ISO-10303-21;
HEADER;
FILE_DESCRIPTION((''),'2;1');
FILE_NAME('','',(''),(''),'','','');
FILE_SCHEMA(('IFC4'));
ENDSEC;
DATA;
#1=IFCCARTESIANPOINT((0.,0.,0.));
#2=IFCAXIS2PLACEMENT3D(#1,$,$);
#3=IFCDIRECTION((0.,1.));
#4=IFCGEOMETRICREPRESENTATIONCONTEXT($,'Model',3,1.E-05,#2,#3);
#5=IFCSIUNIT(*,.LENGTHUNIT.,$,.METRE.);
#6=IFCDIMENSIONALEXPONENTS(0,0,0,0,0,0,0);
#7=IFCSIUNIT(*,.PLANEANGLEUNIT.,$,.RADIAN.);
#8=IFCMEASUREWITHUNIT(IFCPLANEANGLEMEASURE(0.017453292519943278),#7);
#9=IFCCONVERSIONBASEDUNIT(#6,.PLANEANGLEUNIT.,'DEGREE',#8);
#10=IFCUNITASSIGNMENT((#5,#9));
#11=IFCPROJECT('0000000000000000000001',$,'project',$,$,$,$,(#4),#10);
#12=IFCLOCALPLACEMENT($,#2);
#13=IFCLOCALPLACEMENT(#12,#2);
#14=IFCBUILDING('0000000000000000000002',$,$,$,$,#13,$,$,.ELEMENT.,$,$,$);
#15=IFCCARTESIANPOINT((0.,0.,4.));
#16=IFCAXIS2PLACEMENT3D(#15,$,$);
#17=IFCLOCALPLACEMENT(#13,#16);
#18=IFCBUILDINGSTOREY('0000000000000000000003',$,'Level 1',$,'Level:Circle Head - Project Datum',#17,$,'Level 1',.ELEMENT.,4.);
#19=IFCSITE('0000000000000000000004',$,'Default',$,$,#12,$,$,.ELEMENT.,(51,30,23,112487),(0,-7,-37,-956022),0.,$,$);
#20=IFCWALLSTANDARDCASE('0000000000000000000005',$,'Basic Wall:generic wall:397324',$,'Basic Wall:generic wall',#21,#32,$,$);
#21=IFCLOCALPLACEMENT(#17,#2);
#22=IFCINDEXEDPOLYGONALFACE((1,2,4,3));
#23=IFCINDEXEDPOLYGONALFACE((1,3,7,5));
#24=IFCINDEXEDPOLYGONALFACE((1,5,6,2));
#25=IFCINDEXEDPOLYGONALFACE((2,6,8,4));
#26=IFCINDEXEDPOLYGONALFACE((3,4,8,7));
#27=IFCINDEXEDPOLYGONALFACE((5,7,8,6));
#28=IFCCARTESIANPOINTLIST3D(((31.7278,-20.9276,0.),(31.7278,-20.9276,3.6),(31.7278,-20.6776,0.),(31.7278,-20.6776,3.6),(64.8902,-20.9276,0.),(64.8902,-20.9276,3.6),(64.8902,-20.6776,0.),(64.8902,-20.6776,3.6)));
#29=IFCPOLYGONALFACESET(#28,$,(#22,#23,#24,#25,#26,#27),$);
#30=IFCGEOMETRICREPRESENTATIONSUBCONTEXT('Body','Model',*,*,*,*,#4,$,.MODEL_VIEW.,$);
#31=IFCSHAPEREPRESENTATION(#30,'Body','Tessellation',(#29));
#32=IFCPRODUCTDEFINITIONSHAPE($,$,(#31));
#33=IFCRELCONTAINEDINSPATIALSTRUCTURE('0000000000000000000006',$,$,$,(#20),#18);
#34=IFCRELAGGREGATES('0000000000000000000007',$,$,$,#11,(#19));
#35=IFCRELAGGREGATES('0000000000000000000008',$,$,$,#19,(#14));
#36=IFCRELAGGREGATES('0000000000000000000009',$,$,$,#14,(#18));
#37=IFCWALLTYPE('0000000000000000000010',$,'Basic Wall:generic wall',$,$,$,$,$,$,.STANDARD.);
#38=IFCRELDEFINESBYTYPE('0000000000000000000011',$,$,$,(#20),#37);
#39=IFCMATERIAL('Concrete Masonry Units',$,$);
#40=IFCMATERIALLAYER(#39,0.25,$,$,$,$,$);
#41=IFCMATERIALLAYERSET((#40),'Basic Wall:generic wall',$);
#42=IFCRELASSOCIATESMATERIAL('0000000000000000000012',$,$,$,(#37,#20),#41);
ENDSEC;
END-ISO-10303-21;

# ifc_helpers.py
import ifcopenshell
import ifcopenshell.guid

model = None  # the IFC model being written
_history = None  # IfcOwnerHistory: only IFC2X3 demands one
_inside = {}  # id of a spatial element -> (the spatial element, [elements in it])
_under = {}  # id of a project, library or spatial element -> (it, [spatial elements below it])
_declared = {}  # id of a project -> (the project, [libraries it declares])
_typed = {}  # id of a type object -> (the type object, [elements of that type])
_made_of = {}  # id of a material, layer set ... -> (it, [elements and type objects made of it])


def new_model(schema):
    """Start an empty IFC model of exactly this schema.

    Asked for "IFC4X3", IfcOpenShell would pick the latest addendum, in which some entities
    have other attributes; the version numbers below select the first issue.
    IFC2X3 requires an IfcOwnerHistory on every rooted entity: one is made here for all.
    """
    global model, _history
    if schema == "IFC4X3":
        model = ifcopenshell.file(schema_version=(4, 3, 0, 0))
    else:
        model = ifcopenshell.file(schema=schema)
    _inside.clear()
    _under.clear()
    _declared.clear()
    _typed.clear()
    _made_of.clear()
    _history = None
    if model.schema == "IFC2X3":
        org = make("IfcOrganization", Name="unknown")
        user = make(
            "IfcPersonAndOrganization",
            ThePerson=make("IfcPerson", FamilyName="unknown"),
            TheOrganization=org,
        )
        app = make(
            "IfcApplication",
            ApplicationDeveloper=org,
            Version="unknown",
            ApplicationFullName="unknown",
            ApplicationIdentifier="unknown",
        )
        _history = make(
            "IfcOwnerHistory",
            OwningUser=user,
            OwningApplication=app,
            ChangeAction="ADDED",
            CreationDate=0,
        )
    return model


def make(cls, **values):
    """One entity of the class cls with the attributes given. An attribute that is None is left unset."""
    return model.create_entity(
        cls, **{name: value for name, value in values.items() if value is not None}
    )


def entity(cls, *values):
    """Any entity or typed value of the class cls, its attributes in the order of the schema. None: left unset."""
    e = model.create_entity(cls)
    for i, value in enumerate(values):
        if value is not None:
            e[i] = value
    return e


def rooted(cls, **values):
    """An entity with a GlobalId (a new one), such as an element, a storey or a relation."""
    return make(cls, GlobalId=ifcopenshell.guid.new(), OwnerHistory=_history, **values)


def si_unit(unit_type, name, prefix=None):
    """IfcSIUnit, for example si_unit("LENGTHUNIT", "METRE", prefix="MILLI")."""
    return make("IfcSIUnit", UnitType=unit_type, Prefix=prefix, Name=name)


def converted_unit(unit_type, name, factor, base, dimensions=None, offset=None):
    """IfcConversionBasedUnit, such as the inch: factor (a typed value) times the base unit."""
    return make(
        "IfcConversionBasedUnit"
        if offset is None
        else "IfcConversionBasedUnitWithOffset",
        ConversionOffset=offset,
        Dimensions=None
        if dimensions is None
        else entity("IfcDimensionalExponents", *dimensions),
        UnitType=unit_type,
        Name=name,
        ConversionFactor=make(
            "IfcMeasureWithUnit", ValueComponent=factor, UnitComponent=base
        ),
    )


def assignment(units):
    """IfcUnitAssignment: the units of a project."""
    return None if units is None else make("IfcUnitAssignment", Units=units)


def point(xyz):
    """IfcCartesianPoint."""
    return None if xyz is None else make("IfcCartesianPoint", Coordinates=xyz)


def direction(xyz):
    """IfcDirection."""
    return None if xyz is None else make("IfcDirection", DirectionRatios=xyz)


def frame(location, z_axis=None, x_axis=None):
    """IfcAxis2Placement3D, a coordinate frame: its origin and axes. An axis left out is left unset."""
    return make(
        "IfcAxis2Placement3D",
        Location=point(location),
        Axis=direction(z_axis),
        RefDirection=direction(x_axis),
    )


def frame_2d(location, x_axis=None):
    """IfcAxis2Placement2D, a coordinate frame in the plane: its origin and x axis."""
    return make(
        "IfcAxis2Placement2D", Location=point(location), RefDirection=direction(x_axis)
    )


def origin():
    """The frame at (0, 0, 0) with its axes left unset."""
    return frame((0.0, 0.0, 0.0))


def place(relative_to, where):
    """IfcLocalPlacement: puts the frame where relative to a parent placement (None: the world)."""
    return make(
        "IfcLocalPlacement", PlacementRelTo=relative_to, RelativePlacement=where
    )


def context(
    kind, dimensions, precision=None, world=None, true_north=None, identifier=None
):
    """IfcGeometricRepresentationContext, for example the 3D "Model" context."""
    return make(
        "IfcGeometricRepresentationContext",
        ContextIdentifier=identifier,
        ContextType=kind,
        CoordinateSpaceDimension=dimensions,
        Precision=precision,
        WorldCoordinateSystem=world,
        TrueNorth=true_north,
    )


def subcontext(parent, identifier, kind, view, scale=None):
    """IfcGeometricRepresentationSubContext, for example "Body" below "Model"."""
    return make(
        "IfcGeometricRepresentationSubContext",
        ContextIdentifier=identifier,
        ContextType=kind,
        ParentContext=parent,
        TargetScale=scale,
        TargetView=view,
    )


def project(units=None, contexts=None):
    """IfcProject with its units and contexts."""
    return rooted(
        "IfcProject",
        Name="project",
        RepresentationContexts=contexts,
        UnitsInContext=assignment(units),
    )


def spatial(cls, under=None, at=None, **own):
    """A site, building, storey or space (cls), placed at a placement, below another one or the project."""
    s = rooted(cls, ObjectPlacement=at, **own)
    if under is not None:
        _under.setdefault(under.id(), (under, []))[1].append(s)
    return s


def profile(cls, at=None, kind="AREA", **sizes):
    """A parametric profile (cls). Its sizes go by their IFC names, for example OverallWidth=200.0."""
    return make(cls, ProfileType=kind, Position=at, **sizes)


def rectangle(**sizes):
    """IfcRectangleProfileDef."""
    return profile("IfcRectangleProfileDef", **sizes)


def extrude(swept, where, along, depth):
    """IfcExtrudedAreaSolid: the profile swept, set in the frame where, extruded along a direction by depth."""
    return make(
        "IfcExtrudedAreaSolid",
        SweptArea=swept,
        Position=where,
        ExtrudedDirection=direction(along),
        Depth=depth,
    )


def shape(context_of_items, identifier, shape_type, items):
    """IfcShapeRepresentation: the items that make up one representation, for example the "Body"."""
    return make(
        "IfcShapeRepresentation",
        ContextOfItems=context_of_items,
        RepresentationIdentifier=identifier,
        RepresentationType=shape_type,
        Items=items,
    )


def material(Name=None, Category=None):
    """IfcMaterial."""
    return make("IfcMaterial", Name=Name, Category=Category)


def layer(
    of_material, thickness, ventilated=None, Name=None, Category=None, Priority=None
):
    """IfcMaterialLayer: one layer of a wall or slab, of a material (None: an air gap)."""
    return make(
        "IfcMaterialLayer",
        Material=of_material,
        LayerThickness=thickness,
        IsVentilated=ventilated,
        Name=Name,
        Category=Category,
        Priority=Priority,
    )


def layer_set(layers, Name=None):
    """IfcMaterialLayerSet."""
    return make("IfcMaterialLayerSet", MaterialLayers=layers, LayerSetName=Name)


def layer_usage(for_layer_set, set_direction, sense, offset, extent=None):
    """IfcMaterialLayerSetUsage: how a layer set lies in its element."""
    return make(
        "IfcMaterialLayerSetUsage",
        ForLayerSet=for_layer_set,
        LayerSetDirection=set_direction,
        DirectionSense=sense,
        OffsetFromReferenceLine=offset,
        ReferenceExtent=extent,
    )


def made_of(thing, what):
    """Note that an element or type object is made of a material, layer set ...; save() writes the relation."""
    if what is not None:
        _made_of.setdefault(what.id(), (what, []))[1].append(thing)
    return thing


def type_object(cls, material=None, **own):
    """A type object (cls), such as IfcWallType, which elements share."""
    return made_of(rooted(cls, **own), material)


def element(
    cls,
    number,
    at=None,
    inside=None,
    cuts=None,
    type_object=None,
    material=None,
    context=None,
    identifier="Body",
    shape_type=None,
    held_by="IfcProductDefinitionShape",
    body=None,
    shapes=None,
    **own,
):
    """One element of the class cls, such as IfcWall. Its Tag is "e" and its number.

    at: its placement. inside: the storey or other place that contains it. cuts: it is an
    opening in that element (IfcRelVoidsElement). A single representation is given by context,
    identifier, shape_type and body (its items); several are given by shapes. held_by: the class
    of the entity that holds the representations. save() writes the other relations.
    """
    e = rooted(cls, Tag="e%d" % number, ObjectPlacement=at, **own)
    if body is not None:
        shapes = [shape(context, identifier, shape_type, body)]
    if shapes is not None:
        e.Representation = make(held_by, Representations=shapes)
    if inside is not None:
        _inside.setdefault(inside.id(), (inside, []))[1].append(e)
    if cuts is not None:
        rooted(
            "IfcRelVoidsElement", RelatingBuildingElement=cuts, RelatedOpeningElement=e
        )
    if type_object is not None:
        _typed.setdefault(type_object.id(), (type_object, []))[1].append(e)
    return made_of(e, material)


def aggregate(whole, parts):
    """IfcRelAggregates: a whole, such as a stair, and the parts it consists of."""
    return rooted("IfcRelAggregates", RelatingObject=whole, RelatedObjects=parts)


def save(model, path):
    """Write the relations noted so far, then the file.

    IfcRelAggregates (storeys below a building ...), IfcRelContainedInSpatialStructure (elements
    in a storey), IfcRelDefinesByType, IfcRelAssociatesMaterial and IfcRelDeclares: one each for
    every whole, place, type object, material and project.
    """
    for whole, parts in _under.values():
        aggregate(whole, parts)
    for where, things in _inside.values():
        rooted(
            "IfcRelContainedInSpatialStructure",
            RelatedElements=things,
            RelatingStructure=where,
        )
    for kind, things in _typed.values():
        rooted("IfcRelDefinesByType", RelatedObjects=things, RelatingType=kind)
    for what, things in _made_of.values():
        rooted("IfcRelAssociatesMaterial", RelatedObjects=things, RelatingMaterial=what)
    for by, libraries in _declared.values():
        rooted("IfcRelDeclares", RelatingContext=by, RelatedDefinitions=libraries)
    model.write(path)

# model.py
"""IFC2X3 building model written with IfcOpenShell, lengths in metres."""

from ifc_helpers import new_model, entity, si_unit, converted_unit, direction, frame, frame_2d, origin, place, context, subcontext, project, spatial, rectangle, extrude, material, layer, layer_set, layer_usage, type_object, element, save


model = new_model("IFC2X3")

# Units and contexts
model_context = context("Model", 3, precision=1e-05, world=origin(), true_north=direction((0.0, 1.0)))
body_context = subcontext(model_context, "Body", "Model", "MODEL_VIEW")
ifc_project = project(units=[si_unit("LENGTHUNIT", "METRE"), converted_unit("PLANEANGLEUNIT", "DEGREE", entity("IfcPlaneAngleMeasure", 0.017453292519943278), si_unit("PLANEANGLEUNIT", "RADIAN"), dimensions=[0, 0, 0, 0, 0, 0, 0])], contexts=[model_context])

# Site, building, storey
site_placement = place(None, origin())
site = spatial("IfcSite", under=ifc_project, at=site_placement, Name="Default", CompositionType="ELEMENT", RefLatitude=(51, 30, 23, 112487), RefLongitude=(0, -7, -37, -956022), RefElevation=0.0)
building_placement = place(site_placement, origin())
building = spatial("IfcBuilding", under=site, at=building_placement, CompositionType="ELEMENT")
storey_placement = place(building_placement, frame((0.0, 0.0, 4.0)))
storey = spatial("IfcBuildingStorey", under=building, at=storey_placement, Name="Level 1", ObjectType="Level:Circle Head - Project Datum", LongName="Level 1", CompositionType="ELEMENT", Elevation=4.0)

# Shared definitions
ifc_material = material(Name="Concrete Masonry Units")
ifc_layer = layer(ifc_material, 0.25)
ifc_layer_set = layer_set([ifc_layer], Name="Basic Wall:generic wall")
wall_type = type_object("IfcWallType", Name="Basic Wall:generic wall", PredefinedType="STANDARD", material=ifc_layer_set)

# Wall
ifc_layer_usage_1 = layer_usage(ifc_layer_set, "AXIS2", "NEGATIVE", 0.125)
wall_1_placement = place(storey_placement, frame((64.8902, -20.8026, 0.0), z_axis=(0.0, 0.0, 1.0), x_axis=(-1.0, 0.0, 0.0)))
element("IfcWallStandardCase", 1, at=wall_1_placement, inside=storey, type_object=wall_type, material=ifc_layer_usage_1, Name="Basic Wall:generic wall:397324", ObjectType="Basic Wall:generic wall", context=body_context, shape_type="SweptSolid", body=[
    extrude(rectangle(XDim=33.1623, YDim=0.25, at=frame_2d((16.5812, 0.0), x_axis=(-1.0, 0.0))), origin(), (0.0, 0.0, 1.0), 3.6),
])

save(model, "model.ifc")
